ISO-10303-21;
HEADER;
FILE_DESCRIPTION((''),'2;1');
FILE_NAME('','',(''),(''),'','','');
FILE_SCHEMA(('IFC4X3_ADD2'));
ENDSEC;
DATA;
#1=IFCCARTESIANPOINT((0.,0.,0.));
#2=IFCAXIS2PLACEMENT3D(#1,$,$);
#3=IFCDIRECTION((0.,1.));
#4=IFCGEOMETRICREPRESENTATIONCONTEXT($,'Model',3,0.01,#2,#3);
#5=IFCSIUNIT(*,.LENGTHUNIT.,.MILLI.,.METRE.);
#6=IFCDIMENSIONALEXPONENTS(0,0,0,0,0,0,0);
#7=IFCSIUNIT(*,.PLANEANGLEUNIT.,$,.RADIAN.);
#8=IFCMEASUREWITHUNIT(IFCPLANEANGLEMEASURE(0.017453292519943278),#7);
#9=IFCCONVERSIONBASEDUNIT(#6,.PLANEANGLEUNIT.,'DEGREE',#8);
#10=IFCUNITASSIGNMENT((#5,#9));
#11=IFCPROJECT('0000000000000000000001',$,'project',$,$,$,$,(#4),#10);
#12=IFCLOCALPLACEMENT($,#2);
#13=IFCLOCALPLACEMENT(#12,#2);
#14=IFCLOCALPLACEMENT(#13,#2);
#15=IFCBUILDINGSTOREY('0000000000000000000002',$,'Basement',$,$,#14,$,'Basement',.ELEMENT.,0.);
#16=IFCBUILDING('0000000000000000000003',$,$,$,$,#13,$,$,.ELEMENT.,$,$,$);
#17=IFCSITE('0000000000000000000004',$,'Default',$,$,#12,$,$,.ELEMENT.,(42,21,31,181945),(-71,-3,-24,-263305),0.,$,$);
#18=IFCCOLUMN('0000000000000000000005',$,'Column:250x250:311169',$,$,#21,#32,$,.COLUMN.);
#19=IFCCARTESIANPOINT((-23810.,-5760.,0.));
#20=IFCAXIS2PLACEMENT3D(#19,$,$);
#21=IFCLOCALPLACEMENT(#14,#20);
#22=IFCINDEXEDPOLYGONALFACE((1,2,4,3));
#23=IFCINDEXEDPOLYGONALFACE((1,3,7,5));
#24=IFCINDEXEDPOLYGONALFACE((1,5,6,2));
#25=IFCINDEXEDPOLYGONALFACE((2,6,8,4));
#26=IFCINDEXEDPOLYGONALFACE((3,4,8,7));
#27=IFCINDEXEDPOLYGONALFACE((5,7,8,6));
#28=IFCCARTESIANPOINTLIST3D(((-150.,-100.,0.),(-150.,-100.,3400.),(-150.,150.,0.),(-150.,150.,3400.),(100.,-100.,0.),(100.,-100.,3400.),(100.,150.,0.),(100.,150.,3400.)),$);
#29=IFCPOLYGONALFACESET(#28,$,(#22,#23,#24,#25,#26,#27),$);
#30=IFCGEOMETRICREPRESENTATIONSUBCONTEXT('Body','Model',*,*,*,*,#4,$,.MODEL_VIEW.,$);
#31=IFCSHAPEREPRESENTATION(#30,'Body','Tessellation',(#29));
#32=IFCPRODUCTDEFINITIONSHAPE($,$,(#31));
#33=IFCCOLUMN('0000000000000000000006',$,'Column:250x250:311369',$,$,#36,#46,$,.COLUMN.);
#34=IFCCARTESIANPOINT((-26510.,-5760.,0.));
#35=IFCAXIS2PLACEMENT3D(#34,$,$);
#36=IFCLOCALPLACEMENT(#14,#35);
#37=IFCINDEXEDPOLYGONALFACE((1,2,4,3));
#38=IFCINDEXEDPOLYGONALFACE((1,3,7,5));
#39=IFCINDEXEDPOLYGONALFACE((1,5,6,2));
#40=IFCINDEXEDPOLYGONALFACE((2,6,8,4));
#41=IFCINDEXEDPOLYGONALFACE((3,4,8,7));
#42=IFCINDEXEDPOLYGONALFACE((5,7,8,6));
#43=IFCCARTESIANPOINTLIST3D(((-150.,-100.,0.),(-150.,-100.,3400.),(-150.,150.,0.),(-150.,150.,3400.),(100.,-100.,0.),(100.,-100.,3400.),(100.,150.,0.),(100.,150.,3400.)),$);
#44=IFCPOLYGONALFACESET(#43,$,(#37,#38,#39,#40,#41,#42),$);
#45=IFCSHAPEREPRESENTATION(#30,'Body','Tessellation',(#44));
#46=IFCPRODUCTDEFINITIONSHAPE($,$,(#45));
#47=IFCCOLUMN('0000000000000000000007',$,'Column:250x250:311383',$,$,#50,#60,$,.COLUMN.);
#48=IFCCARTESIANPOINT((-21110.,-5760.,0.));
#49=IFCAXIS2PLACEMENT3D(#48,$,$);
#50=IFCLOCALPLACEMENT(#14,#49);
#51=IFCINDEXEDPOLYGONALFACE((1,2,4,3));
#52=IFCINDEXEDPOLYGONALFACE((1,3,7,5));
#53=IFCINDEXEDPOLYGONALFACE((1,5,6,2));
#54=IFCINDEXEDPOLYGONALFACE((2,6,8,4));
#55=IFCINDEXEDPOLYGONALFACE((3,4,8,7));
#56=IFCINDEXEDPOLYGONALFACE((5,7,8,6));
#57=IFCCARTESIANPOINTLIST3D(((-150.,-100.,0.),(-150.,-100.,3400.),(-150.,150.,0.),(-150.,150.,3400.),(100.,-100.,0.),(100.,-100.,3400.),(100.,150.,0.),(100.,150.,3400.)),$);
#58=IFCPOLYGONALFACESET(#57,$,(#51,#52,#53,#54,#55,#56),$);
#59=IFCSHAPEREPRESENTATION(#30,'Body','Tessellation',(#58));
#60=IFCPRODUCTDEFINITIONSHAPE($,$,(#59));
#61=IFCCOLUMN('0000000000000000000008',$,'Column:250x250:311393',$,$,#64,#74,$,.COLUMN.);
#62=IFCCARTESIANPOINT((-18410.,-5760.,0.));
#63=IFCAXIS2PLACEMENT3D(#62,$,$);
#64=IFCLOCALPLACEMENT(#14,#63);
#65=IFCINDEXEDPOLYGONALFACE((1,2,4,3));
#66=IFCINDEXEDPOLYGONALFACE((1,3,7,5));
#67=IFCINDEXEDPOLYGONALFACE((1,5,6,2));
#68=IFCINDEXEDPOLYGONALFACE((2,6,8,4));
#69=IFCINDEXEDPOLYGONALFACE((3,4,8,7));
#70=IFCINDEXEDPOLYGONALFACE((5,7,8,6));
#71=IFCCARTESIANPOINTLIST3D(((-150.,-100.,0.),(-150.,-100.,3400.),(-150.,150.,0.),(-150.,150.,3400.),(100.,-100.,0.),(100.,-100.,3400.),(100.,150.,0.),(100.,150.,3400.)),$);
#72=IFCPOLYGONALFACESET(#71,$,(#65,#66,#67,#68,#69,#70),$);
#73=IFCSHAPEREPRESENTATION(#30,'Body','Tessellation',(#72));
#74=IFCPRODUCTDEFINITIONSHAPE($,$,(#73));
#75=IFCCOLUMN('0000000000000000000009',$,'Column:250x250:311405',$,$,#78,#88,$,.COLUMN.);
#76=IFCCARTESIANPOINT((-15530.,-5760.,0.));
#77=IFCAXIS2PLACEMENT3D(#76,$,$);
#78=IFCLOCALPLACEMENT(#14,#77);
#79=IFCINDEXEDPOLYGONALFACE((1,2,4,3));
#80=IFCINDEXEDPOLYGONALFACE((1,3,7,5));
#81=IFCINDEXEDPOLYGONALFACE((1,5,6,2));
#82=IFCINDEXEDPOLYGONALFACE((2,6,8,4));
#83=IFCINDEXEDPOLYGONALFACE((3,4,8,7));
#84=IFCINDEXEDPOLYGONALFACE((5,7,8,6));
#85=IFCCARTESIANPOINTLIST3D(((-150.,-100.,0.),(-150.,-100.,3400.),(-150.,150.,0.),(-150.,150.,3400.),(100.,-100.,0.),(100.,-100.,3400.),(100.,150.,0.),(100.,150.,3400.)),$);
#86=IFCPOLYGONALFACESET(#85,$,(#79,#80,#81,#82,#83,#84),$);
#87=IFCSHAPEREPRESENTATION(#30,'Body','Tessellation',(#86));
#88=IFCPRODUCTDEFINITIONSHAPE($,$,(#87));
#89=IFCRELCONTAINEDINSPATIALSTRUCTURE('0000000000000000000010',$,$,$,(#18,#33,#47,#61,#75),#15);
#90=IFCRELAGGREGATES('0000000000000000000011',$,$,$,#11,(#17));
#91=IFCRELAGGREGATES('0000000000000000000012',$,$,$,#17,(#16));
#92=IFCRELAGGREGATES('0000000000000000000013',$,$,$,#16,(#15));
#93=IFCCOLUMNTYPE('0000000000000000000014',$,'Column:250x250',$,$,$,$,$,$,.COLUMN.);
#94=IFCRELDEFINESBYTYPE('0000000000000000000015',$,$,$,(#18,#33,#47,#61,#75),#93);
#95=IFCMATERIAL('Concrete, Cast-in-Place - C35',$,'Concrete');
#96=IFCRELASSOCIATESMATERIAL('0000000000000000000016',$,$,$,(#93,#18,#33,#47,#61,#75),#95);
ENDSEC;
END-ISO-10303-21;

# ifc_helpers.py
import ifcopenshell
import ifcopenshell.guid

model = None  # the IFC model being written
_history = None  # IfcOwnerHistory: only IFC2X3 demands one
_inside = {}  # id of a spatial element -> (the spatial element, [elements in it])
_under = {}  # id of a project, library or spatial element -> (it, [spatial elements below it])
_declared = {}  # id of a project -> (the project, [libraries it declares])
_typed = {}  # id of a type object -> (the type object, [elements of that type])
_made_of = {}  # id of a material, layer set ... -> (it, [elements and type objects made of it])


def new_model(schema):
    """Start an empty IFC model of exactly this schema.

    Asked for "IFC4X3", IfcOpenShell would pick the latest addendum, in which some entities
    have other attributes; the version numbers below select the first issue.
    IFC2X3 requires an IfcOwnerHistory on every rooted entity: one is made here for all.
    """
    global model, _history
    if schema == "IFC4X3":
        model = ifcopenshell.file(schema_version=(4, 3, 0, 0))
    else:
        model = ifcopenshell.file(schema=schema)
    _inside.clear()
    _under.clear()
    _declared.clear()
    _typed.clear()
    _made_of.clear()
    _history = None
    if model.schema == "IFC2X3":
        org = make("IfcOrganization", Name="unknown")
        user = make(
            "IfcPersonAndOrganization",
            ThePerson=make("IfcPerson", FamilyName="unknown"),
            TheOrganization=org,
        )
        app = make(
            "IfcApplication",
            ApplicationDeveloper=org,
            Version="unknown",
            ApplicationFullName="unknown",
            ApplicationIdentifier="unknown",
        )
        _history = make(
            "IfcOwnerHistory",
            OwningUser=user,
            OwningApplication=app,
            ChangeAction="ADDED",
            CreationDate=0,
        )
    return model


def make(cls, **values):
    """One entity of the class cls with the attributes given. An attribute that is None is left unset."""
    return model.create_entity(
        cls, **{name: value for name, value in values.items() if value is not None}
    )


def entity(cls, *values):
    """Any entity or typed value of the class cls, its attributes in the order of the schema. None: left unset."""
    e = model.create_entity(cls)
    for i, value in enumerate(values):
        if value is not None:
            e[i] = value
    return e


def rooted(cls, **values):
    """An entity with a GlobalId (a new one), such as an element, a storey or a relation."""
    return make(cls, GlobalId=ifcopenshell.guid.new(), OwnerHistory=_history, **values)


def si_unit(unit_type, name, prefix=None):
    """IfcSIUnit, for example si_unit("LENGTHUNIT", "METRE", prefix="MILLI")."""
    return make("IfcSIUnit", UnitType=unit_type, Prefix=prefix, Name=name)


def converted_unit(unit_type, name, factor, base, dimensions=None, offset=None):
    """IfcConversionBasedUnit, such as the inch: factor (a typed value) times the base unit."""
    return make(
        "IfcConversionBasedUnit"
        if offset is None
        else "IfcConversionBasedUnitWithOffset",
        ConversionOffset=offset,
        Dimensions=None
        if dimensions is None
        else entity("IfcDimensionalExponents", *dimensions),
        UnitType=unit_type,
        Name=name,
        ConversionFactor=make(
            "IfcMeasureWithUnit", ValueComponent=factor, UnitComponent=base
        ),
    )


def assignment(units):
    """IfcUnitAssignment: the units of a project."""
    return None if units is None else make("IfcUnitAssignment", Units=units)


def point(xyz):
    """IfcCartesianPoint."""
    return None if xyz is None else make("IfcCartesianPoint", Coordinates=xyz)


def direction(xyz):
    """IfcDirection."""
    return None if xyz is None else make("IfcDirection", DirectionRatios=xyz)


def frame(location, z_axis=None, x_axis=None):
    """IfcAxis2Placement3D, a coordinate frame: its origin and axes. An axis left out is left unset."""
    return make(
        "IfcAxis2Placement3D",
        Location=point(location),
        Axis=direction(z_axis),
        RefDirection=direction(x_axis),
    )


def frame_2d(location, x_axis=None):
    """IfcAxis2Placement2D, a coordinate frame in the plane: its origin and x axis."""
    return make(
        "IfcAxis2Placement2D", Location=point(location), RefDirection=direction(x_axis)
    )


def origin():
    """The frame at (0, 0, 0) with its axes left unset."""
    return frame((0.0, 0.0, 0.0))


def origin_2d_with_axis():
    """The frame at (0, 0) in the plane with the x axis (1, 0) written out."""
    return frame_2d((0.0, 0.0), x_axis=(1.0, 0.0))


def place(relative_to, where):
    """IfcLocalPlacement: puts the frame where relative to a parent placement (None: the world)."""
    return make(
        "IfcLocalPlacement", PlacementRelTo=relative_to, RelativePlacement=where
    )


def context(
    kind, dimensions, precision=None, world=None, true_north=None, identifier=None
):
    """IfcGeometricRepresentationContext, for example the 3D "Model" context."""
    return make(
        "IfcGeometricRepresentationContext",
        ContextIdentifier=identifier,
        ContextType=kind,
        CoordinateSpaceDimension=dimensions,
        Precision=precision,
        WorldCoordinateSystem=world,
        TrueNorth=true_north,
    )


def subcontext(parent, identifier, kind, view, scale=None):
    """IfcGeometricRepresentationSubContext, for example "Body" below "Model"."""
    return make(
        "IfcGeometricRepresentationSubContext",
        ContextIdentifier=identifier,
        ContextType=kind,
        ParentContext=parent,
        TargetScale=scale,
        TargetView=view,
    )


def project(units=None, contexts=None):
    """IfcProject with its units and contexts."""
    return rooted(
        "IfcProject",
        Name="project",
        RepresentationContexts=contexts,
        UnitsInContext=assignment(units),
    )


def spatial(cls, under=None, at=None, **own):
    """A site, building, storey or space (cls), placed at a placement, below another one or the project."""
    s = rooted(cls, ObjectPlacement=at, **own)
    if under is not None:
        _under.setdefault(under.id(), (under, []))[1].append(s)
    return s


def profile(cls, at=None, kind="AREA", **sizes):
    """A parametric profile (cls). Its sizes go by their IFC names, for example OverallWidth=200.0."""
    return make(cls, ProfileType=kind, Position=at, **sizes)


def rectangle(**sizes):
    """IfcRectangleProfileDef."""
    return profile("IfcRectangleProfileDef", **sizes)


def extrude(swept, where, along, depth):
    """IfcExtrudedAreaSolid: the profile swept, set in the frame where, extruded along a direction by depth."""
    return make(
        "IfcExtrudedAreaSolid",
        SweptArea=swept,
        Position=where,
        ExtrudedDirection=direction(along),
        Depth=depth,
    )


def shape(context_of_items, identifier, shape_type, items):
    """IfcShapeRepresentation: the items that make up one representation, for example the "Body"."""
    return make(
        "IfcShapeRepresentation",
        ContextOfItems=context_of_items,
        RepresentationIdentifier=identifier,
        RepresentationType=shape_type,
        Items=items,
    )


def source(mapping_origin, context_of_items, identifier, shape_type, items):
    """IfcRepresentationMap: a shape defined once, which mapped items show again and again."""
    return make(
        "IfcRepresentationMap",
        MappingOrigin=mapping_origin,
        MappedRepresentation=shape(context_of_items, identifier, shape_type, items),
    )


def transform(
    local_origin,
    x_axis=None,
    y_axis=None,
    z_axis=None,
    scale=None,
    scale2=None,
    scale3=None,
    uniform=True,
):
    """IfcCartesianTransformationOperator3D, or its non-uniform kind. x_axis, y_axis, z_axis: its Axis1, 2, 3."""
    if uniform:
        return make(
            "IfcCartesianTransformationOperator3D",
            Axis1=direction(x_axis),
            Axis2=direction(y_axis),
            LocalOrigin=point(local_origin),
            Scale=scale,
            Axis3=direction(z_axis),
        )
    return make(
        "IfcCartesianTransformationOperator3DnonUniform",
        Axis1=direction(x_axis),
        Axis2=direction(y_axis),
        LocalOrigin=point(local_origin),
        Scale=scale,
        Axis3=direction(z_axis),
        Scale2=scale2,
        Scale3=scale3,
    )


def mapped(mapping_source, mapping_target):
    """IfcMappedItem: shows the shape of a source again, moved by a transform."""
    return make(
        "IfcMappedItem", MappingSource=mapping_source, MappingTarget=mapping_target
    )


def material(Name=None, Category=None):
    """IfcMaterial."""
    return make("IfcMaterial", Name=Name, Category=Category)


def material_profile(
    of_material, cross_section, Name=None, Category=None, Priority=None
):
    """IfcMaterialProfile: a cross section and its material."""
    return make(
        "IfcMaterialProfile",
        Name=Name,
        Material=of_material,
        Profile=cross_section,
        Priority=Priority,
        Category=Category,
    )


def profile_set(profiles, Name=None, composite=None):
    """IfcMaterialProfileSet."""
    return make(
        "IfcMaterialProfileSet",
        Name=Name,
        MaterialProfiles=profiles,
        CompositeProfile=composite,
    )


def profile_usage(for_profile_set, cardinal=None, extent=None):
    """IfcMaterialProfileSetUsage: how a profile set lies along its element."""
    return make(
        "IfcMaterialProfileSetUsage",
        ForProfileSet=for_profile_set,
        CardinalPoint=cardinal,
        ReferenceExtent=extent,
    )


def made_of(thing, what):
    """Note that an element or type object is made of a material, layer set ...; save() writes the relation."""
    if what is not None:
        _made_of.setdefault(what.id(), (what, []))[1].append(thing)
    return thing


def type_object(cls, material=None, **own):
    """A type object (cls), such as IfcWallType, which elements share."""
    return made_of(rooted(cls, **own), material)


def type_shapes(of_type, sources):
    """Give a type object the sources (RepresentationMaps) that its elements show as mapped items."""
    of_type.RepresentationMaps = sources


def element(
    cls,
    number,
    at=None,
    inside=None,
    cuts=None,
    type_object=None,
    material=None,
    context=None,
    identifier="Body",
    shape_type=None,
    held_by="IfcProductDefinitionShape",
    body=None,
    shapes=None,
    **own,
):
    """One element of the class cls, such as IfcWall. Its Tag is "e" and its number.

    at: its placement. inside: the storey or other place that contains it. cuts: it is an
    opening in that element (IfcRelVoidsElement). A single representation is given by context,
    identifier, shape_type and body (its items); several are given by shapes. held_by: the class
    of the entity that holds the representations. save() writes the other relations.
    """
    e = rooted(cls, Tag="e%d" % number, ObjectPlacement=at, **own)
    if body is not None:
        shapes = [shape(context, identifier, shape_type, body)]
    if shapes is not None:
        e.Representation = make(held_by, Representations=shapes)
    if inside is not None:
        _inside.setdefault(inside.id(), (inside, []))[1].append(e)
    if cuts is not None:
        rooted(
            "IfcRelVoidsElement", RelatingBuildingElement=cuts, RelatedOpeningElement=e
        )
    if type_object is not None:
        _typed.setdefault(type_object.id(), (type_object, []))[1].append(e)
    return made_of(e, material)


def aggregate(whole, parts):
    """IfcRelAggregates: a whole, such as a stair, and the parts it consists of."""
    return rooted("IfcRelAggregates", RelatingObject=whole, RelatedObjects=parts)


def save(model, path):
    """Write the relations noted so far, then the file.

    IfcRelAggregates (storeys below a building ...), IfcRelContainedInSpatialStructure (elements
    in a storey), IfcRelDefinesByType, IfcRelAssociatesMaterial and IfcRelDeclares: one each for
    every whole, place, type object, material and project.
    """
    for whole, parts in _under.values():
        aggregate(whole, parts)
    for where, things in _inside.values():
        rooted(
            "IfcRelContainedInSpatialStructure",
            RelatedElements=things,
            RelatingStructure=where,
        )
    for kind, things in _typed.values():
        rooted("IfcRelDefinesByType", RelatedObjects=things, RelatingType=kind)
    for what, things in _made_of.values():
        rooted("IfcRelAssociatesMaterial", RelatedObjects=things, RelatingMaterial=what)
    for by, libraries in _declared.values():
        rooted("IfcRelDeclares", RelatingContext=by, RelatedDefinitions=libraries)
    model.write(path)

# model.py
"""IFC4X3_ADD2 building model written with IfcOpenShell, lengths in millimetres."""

from ifc_helpers import new_model, entity, si_unit, converted_unit, direction, frame, origin, origin_2d_with_axis, place, context, subcontext, project, spatial, rectangle, extrude, source, transform, mapped, material, material_profile, profile_set, profile_usage, type_object, type_shapes, element, save


model = new_model("IFC4X3_ADD2")

# Units and contexts
model_context = context("Model", 3, precision=0.01, world=origin(), true_north=direction((0.0, 1.0)))
body_context = subcontext(model_context, "Body", "Model", "MODEL_VIEW")
ifc_project = project(units=[si_unit("LENGTHUNIT", "METRE", prefix="MILLI"), converted_unit("PLANEANGLEUNIT", "DEGREE", entity("IfcPlaneAngleMeasure", 0.017453292519943278), si_unit("PLANEANGLEUNIT", "RADIAN"), dimensions=[0, 0, 0, 0, 0, 0, 0])], contexts=[model_context])

# Site, building, storey
site_placement = place(None, origin())
site = spatial("IfcSite", under=ifc_project, at=site_placement, Name="Default", CompositionType="ELEMENT", RefLatitude=(42, 21, 31, 181945), RefLongitude=(-71, -3, -24, -263305), RefElevation=0.0)
building_placement = place(site_placement, origin())
building = spatial("IfcBuilding", under=site, at=building_placement, CompositionType="ELEMENT")
storey_placement = place(building_placement, origin())
storey = spatial("IfcBuildingStorey", under=building, at=storey_placement, Name="Basement", LongName="Basement", CompositionType="ELEMENT", Elevation=0.0)

# Columns
ifc_material = material(Name="Concrete, Cast-in-Place - C35", Category="Concrete")
ifc_material_profile = material_profile(ifc_material, rectangle(XDim=250.0, YDim=250.0, at=origin_2d_with_axis()), Name="250x250")
ifc_profile_set = profile_set([ifc_material_profile], Name="250x250")
ifc_profile_usage = profile_usage(ifc_profile_set)
column_type = type_object("IfcColumnType", Name="Column:250x250", PredefinedType="COLUMN", material=ifc_profile_set)
shared_shape = source(origin(), body_context, "Body", "SweptSolid", [
    extrude(rectangle(XDim=250.0, YDim=250.0, at=origin_2d_with_axis()), frame((-25.0, 25.0, 0.0), z_axis=(0.0, 0.0, 1.0), x_axis=(-1.0, 0.0, 0.0)), (0.0, 0.0, 1.0), 3400.0),
])
type_shapes(column_type, [shared_shape])
for number, where, name in (
    (1, (-23810.0, -5760.0, 0.0), "Column:250x250:311169"),
    (2, (-26510.0, -5760.0, 0.0), "Column:250x250:311369"),
    (3, (-21110.0, -5760.0, 0.0), "Column:250x250:311383"),
    (4, (-18410.0, -5760.0, 0.0), "Column:250x250:311393"),
    (5, (-15530.0, -5760.0, 0.0), "Column:250x250:311405"),
):
    element("IfcColumn", number, at=place(storey_placement, frame(where)), inside=storey, type_object=column_type, material=ifc_profile_usage, Name=name, PredefinedType="COLUMN", context=body_context, shape_type="MappedRepresentation", body=[
        mapped(shared_shape, transform((0.0, 0.0, 0.0), scale=1.0)),
    ])

save(model, "model.ifc")
